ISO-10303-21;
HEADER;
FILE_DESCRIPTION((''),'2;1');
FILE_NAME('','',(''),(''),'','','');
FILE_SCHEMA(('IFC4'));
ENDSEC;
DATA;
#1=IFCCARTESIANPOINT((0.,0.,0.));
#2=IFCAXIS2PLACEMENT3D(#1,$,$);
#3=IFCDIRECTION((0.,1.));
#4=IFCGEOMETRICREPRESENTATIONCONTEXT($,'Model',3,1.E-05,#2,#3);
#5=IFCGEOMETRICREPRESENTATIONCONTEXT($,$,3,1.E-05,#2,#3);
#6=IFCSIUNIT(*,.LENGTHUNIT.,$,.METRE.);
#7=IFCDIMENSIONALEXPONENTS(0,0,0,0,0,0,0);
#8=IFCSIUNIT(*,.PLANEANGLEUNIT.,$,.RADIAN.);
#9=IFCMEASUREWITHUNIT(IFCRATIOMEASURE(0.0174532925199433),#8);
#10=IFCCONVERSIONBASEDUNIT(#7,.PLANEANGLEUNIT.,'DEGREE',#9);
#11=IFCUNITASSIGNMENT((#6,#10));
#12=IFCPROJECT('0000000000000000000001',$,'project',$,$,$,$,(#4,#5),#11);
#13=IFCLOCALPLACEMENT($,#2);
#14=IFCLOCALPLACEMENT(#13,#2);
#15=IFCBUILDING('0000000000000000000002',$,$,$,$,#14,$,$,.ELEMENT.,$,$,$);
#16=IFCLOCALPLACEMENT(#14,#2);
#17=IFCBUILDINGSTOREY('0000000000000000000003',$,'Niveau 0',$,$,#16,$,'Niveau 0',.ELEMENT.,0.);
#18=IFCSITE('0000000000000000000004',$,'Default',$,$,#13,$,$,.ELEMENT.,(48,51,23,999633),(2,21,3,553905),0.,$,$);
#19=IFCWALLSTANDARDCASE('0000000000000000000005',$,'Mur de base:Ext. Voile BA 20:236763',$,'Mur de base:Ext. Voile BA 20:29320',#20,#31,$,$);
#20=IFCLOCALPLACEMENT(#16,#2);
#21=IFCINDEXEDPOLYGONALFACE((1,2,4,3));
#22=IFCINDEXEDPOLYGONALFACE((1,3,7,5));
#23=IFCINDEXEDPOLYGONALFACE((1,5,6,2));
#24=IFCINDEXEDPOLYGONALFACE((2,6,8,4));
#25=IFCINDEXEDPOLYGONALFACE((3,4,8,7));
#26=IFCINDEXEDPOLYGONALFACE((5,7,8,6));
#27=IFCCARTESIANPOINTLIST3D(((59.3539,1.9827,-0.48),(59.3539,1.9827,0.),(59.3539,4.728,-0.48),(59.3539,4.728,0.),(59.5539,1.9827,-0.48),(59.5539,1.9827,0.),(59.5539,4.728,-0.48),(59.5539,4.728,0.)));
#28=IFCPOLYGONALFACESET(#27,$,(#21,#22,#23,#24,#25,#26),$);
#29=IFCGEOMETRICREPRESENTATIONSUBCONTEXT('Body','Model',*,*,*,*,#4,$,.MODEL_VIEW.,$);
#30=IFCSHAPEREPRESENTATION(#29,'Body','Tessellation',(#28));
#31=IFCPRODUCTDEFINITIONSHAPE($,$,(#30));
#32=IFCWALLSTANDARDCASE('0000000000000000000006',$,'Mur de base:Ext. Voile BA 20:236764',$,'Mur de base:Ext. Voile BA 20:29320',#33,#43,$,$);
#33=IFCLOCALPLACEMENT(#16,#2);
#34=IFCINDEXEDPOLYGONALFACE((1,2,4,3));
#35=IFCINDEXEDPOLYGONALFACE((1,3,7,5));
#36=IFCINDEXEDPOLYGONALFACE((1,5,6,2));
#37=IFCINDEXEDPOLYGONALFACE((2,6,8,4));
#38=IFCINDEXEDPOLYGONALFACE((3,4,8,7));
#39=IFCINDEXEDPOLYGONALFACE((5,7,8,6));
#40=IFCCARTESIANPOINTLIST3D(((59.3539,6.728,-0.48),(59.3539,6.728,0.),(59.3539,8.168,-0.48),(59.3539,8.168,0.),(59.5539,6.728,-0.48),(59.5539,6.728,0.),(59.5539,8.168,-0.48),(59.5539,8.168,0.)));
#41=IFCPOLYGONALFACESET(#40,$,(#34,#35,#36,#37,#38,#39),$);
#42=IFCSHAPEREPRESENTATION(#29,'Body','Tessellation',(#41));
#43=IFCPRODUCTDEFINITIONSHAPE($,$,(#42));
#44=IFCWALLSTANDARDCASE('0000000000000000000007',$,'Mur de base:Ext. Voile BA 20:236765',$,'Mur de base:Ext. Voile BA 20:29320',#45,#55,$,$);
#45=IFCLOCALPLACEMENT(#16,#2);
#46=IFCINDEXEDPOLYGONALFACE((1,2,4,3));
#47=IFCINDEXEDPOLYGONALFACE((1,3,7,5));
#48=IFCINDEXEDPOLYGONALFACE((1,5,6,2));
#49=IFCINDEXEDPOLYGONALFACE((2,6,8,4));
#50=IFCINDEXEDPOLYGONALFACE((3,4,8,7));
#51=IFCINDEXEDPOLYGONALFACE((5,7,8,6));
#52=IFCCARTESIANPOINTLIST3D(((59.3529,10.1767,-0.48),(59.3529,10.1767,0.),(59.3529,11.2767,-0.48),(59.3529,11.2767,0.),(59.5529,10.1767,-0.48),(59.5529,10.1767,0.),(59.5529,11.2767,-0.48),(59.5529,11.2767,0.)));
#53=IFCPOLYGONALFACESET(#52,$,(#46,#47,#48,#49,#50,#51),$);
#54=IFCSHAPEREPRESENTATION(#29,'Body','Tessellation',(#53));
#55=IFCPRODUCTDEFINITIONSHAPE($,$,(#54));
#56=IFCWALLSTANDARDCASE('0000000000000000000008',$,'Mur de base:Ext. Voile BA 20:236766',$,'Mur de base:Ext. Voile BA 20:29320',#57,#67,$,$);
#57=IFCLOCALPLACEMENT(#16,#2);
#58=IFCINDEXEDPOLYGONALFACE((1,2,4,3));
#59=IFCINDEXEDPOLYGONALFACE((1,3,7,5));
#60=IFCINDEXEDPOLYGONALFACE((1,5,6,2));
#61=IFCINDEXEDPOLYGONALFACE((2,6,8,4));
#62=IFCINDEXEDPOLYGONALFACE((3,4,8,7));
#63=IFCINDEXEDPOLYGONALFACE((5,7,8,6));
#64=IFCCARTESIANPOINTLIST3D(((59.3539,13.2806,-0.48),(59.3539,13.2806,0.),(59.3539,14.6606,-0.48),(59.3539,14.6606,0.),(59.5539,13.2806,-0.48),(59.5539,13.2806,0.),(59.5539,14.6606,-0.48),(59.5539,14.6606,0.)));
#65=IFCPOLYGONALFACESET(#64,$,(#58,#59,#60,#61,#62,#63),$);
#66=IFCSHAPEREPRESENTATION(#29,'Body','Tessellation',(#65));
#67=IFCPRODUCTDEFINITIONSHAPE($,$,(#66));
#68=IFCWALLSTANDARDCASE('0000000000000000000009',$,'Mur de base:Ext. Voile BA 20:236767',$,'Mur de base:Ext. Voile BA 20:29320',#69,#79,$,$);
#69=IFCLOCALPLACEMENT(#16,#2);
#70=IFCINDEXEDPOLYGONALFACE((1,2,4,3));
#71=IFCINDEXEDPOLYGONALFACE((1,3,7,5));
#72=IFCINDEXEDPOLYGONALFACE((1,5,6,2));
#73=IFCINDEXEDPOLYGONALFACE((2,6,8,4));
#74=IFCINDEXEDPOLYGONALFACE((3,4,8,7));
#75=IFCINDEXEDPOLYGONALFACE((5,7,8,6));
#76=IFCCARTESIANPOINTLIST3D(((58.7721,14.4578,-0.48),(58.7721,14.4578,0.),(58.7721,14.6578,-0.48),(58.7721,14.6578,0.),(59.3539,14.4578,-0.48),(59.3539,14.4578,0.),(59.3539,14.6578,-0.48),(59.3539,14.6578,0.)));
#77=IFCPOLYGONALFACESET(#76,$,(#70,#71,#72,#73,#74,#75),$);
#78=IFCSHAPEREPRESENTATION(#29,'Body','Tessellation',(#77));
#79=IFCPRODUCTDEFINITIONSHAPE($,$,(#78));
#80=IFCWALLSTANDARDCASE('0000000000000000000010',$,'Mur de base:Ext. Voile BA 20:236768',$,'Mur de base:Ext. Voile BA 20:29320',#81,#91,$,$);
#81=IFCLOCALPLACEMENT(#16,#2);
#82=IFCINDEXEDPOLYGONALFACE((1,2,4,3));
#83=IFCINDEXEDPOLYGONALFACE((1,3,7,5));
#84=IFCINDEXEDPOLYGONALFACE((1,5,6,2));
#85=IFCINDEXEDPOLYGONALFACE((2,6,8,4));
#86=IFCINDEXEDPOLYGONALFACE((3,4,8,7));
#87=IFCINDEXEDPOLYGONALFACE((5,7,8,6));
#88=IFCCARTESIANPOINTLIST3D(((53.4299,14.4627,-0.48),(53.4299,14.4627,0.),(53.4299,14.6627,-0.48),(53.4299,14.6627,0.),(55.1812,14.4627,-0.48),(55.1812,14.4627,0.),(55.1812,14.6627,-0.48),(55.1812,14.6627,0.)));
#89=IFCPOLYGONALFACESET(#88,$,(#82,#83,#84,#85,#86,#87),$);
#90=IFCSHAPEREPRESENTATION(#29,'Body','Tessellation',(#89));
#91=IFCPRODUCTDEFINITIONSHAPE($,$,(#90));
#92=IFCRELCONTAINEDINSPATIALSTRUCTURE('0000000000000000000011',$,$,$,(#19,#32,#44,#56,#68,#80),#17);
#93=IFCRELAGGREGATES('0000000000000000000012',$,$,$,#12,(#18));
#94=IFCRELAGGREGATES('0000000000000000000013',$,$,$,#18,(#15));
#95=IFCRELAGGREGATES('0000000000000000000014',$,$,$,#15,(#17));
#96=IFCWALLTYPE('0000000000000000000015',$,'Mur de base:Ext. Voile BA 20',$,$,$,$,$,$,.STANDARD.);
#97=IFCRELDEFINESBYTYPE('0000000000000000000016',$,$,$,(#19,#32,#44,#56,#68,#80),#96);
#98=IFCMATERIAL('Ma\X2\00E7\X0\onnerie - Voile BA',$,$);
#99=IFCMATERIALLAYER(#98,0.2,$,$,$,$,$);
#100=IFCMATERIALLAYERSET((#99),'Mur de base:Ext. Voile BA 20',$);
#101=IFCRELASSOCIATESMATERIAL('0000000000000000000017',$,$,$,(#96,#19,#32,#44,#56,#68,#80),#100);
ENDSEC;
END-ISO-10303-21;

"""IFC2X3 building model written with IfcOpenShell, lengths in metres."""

from ifc_helpers import new_model, entity, si_unit, converted_unit, direction, frame, frame_2d, origin, place, context, subcontext, project, spatial, rectangle, extrude, material, layer, layer_set, layer_usage, type_object, element, save


model = new_model("IFC2X3")

# Units and contexts
model_context = context("Model", 3, precision=1e-05, world=origin(), true_north=direction((0.0, 1.0)))
context_of_model = context(None, 3, precision=1e-05, world=origin(), true_north=direction((0.0, 1.0)))
body_context = subcontext(model_context, "Body", "Model", "MODEL_VIEW")
ifc_project = project(units=[si_unit("LENGTHUNIT", "METRE"), converted_unit("PLANEANGLEUNIT", "DEGREE", entity("IfcRatioMeasure", 0.0174532925199433), si_unit("PLANEANGLEUNIT", "RADIAN"), dimensions=[0, 0, 0, 0, 0, 0, 0])], contexts=[model_context, context_of_model])

# Site, building, storey
site_placement = place(None, origin())
site = spatial("IfcSite", under=ifc_project, at=site_placement, Name="Default", CompositionType="ELEMENT", RefLatitude=(48, 51, 23, 999633), RefLongitude=(2, 21, 3, 553905), RefElevation=0.0)
building_placement = place(site_placement, origin())
building = spatial("IfcBuilding", under=site, at=building_placement, CompositionType="ELEMENT")
storey_placement = place(building_placement, origin())
storey = spatial("IfcBuildingStorey", under=building, at=storey_placement, Name="Niveau 0", LongName="Niveau 0", CompositionType="ELEMENT", Elevation=0.0)

# Shared definitions
ifc_material = material(Name="Maçonnerie - Voile BA")
ifc_layer = layer(ifc_material, 0.2)
ifc_layer_set = layer_set([ifc_layer], Name="Mur de base:Ext. Voile BA 20")
wall_type = type_object("IfcWallType", Name="Mur de base:Ext. Voile BA 20", PredefinedType="STANDARD", material=ifc_layer_set)

# Walls
ifc_layer_usage_1 = layer_usage(ifc_layer_set, "AXIS2", "NEGATIVE", 0.1)
wall_1_placement = place(storey_placement, frame((59.4539, 1.9827, -0.48), z_axis=(0.0, 0.0, 1.0), x_axis=(0.0, 1.0, 0.0)))
element("IfcWallStandardCase", 1, at=wall_1_placement, inside=storey, type_object=wall_type, material=ifc_layer_usage_1, Name="Mur de base:Ext. Voile BA 20:236763", ObjectType="Mur de base:Ext. Voile BA 20:29320", context=body_context, shape_type="SweptSolid", body=[
    extrude(rectangle(XDim=2.7453, YDim=0.2, at=frame_2d((1.3726, 0.0), x_axis=(-1.0, 0.0))), origin(), (0.0, 0.0, 1.0), 0.48),
])
ifc_layer_usage_2 = layer_usage(ifc_layer_set, "AXIS2", "NEGATIVE", 0.1)
wall_2_placement = place(storey_placement, frame((59.4539, 6.728, -0.48), z_axis=(0.0, 0.0, 1.0), x_axis=(0.0, 1.0, 0.0)))
element("IfcWallStandardCase", 2, at=wall_2_placement, inside=storey, type_object=wall_type, material=ifc_layer_usage_2, Name="Mur de base:Ext. Voile BA 20:236764", ObjectType="Mur de base:Ext. Voile BA 20:29320", context=body_context, shape_type="SweptSolid", body=[
    extrude(rectangle(XDim=1.44, YDim=0.2, at=frame_2d((0.72, 0.0), x_axis=(-1.0, 0.0))), origin(), (0.0, 0.0, 1.0), 0.48),
])
ifc_layer_usage_3 = layer_usage(ifc_layer_set, "AXIS2", "NEGATIVE", 0.1)
wall_3_placement = place(storey_placement, frame((59.4529, 10.1767, -0.48), z_axis=(0.0, 0.0, 1.0), x_axis=(0.0, 1.0, 0.0)))
element("IfcWallStandardCase", 3, at=wall_3_placement, inside=storey, type_object=wall_type, material=ifc_layer_usage_3, Name="Mur de base:Ext. Voile BA 20:236765", ObjectType="Mur de base:Ext. Voile BA 20:29320", context=body_context, shape_type="SweptSolid", body=[
    extrude(rectangle(XDim=1.1, YDim=0.2, at=frame_2d((0.55, 0.0), x_axis=(-1.0, 0.0))), origin(), (0.0, 0.0, 1.0), 0.48),
])
ifc_layer_usage_4 = layer_usage(ifc_layer_set, "AXIS2", "NEGATIVE", 0.1)
wall_4_placement = place(storey_placement, frame((59.4539, 13.2806, -0.48), z_axis=(0.0, 0.0, 1.0), x_axis=(0.0, 1.0, 0.0)))
element("IfcWallStandardCase", 4, at=wall_4_placement, inside=storey, type_object=wall_type, material=ifc_layer_usage_4, Name="Mur de base:Ext. Voile BA 20:236766", ObjectType="Mur de base:Ext. Voile BA 20:29320", context=body_context, shape_type="SweptSolid", body=[
    extrude(rectangle(XDim=1.38, YDim=0.2, at=frame_2d((0.69, 0.0), x_axis=(-1.0, 0.0))), origin(), (0.0, 0.0, 1.0), 0.48),
])
ifc_layer_usage_5 = layer_usage(ifc_layer_set, "AXIS2", "NEGATIVE", 0.1)
wall_5_placement = place(storey_placement, frame((59.3539, 14.5578, -0.48), z_axis=(0.0, 0.0, 1.0), x_axis=(-1.0, 0.0, 0.0)))
element("IfcWallStandardCase", 5, at=wall_5_placement, inside=storey, type_object=wall_type, material=ifc_layer_usage_5, Name="Mur de base:Ext. Voile BA 20:236767", ObjectType="Mur de base:Ext. Voile BA 20:29320", context=body_context, shape_type="SweptSolid", body=[
    extrude(rectangle(XDim=0.5818, YDim=0.2, at=frame_2d((0.2909, 0.0), x_axis=(-1.0, 0.0))), origin(), (0.0, 0.0, 1.0), 0.48),
])
ifc_layer_usage_6 = layer_usage(ifc_layer_set, "AXIS2", "NEGATIVE", 0.1)
wall_6_placement = place(storey_placement, frame((55.1812, 14.5627, -0.48), z_axis=(0.0, 0.0, 1.0), x_axis=(-1.0, 0.0, 0.0)))
element("IfcWallStandardCase", 6, at=wall_6_placement, inside=storey, type_object=wall_type, material=ifc_layer_usage_6, Name="Mur de base:Ext. Voile BA 20:236768", ObjectType="Mur de base:Ext. Voile BA 20:29320", context=body_context, shape_type="SweptSolid", body=[
    extrude(rectangle(XDim=1.7513, YDim=0.2, at=frame_2d((0.8756, 0.0), x_axis=(-1.0, 0.0))), origin(), (0.0, 0.0, 1.0), 0.48),
])

save(model, "model.ifc")
